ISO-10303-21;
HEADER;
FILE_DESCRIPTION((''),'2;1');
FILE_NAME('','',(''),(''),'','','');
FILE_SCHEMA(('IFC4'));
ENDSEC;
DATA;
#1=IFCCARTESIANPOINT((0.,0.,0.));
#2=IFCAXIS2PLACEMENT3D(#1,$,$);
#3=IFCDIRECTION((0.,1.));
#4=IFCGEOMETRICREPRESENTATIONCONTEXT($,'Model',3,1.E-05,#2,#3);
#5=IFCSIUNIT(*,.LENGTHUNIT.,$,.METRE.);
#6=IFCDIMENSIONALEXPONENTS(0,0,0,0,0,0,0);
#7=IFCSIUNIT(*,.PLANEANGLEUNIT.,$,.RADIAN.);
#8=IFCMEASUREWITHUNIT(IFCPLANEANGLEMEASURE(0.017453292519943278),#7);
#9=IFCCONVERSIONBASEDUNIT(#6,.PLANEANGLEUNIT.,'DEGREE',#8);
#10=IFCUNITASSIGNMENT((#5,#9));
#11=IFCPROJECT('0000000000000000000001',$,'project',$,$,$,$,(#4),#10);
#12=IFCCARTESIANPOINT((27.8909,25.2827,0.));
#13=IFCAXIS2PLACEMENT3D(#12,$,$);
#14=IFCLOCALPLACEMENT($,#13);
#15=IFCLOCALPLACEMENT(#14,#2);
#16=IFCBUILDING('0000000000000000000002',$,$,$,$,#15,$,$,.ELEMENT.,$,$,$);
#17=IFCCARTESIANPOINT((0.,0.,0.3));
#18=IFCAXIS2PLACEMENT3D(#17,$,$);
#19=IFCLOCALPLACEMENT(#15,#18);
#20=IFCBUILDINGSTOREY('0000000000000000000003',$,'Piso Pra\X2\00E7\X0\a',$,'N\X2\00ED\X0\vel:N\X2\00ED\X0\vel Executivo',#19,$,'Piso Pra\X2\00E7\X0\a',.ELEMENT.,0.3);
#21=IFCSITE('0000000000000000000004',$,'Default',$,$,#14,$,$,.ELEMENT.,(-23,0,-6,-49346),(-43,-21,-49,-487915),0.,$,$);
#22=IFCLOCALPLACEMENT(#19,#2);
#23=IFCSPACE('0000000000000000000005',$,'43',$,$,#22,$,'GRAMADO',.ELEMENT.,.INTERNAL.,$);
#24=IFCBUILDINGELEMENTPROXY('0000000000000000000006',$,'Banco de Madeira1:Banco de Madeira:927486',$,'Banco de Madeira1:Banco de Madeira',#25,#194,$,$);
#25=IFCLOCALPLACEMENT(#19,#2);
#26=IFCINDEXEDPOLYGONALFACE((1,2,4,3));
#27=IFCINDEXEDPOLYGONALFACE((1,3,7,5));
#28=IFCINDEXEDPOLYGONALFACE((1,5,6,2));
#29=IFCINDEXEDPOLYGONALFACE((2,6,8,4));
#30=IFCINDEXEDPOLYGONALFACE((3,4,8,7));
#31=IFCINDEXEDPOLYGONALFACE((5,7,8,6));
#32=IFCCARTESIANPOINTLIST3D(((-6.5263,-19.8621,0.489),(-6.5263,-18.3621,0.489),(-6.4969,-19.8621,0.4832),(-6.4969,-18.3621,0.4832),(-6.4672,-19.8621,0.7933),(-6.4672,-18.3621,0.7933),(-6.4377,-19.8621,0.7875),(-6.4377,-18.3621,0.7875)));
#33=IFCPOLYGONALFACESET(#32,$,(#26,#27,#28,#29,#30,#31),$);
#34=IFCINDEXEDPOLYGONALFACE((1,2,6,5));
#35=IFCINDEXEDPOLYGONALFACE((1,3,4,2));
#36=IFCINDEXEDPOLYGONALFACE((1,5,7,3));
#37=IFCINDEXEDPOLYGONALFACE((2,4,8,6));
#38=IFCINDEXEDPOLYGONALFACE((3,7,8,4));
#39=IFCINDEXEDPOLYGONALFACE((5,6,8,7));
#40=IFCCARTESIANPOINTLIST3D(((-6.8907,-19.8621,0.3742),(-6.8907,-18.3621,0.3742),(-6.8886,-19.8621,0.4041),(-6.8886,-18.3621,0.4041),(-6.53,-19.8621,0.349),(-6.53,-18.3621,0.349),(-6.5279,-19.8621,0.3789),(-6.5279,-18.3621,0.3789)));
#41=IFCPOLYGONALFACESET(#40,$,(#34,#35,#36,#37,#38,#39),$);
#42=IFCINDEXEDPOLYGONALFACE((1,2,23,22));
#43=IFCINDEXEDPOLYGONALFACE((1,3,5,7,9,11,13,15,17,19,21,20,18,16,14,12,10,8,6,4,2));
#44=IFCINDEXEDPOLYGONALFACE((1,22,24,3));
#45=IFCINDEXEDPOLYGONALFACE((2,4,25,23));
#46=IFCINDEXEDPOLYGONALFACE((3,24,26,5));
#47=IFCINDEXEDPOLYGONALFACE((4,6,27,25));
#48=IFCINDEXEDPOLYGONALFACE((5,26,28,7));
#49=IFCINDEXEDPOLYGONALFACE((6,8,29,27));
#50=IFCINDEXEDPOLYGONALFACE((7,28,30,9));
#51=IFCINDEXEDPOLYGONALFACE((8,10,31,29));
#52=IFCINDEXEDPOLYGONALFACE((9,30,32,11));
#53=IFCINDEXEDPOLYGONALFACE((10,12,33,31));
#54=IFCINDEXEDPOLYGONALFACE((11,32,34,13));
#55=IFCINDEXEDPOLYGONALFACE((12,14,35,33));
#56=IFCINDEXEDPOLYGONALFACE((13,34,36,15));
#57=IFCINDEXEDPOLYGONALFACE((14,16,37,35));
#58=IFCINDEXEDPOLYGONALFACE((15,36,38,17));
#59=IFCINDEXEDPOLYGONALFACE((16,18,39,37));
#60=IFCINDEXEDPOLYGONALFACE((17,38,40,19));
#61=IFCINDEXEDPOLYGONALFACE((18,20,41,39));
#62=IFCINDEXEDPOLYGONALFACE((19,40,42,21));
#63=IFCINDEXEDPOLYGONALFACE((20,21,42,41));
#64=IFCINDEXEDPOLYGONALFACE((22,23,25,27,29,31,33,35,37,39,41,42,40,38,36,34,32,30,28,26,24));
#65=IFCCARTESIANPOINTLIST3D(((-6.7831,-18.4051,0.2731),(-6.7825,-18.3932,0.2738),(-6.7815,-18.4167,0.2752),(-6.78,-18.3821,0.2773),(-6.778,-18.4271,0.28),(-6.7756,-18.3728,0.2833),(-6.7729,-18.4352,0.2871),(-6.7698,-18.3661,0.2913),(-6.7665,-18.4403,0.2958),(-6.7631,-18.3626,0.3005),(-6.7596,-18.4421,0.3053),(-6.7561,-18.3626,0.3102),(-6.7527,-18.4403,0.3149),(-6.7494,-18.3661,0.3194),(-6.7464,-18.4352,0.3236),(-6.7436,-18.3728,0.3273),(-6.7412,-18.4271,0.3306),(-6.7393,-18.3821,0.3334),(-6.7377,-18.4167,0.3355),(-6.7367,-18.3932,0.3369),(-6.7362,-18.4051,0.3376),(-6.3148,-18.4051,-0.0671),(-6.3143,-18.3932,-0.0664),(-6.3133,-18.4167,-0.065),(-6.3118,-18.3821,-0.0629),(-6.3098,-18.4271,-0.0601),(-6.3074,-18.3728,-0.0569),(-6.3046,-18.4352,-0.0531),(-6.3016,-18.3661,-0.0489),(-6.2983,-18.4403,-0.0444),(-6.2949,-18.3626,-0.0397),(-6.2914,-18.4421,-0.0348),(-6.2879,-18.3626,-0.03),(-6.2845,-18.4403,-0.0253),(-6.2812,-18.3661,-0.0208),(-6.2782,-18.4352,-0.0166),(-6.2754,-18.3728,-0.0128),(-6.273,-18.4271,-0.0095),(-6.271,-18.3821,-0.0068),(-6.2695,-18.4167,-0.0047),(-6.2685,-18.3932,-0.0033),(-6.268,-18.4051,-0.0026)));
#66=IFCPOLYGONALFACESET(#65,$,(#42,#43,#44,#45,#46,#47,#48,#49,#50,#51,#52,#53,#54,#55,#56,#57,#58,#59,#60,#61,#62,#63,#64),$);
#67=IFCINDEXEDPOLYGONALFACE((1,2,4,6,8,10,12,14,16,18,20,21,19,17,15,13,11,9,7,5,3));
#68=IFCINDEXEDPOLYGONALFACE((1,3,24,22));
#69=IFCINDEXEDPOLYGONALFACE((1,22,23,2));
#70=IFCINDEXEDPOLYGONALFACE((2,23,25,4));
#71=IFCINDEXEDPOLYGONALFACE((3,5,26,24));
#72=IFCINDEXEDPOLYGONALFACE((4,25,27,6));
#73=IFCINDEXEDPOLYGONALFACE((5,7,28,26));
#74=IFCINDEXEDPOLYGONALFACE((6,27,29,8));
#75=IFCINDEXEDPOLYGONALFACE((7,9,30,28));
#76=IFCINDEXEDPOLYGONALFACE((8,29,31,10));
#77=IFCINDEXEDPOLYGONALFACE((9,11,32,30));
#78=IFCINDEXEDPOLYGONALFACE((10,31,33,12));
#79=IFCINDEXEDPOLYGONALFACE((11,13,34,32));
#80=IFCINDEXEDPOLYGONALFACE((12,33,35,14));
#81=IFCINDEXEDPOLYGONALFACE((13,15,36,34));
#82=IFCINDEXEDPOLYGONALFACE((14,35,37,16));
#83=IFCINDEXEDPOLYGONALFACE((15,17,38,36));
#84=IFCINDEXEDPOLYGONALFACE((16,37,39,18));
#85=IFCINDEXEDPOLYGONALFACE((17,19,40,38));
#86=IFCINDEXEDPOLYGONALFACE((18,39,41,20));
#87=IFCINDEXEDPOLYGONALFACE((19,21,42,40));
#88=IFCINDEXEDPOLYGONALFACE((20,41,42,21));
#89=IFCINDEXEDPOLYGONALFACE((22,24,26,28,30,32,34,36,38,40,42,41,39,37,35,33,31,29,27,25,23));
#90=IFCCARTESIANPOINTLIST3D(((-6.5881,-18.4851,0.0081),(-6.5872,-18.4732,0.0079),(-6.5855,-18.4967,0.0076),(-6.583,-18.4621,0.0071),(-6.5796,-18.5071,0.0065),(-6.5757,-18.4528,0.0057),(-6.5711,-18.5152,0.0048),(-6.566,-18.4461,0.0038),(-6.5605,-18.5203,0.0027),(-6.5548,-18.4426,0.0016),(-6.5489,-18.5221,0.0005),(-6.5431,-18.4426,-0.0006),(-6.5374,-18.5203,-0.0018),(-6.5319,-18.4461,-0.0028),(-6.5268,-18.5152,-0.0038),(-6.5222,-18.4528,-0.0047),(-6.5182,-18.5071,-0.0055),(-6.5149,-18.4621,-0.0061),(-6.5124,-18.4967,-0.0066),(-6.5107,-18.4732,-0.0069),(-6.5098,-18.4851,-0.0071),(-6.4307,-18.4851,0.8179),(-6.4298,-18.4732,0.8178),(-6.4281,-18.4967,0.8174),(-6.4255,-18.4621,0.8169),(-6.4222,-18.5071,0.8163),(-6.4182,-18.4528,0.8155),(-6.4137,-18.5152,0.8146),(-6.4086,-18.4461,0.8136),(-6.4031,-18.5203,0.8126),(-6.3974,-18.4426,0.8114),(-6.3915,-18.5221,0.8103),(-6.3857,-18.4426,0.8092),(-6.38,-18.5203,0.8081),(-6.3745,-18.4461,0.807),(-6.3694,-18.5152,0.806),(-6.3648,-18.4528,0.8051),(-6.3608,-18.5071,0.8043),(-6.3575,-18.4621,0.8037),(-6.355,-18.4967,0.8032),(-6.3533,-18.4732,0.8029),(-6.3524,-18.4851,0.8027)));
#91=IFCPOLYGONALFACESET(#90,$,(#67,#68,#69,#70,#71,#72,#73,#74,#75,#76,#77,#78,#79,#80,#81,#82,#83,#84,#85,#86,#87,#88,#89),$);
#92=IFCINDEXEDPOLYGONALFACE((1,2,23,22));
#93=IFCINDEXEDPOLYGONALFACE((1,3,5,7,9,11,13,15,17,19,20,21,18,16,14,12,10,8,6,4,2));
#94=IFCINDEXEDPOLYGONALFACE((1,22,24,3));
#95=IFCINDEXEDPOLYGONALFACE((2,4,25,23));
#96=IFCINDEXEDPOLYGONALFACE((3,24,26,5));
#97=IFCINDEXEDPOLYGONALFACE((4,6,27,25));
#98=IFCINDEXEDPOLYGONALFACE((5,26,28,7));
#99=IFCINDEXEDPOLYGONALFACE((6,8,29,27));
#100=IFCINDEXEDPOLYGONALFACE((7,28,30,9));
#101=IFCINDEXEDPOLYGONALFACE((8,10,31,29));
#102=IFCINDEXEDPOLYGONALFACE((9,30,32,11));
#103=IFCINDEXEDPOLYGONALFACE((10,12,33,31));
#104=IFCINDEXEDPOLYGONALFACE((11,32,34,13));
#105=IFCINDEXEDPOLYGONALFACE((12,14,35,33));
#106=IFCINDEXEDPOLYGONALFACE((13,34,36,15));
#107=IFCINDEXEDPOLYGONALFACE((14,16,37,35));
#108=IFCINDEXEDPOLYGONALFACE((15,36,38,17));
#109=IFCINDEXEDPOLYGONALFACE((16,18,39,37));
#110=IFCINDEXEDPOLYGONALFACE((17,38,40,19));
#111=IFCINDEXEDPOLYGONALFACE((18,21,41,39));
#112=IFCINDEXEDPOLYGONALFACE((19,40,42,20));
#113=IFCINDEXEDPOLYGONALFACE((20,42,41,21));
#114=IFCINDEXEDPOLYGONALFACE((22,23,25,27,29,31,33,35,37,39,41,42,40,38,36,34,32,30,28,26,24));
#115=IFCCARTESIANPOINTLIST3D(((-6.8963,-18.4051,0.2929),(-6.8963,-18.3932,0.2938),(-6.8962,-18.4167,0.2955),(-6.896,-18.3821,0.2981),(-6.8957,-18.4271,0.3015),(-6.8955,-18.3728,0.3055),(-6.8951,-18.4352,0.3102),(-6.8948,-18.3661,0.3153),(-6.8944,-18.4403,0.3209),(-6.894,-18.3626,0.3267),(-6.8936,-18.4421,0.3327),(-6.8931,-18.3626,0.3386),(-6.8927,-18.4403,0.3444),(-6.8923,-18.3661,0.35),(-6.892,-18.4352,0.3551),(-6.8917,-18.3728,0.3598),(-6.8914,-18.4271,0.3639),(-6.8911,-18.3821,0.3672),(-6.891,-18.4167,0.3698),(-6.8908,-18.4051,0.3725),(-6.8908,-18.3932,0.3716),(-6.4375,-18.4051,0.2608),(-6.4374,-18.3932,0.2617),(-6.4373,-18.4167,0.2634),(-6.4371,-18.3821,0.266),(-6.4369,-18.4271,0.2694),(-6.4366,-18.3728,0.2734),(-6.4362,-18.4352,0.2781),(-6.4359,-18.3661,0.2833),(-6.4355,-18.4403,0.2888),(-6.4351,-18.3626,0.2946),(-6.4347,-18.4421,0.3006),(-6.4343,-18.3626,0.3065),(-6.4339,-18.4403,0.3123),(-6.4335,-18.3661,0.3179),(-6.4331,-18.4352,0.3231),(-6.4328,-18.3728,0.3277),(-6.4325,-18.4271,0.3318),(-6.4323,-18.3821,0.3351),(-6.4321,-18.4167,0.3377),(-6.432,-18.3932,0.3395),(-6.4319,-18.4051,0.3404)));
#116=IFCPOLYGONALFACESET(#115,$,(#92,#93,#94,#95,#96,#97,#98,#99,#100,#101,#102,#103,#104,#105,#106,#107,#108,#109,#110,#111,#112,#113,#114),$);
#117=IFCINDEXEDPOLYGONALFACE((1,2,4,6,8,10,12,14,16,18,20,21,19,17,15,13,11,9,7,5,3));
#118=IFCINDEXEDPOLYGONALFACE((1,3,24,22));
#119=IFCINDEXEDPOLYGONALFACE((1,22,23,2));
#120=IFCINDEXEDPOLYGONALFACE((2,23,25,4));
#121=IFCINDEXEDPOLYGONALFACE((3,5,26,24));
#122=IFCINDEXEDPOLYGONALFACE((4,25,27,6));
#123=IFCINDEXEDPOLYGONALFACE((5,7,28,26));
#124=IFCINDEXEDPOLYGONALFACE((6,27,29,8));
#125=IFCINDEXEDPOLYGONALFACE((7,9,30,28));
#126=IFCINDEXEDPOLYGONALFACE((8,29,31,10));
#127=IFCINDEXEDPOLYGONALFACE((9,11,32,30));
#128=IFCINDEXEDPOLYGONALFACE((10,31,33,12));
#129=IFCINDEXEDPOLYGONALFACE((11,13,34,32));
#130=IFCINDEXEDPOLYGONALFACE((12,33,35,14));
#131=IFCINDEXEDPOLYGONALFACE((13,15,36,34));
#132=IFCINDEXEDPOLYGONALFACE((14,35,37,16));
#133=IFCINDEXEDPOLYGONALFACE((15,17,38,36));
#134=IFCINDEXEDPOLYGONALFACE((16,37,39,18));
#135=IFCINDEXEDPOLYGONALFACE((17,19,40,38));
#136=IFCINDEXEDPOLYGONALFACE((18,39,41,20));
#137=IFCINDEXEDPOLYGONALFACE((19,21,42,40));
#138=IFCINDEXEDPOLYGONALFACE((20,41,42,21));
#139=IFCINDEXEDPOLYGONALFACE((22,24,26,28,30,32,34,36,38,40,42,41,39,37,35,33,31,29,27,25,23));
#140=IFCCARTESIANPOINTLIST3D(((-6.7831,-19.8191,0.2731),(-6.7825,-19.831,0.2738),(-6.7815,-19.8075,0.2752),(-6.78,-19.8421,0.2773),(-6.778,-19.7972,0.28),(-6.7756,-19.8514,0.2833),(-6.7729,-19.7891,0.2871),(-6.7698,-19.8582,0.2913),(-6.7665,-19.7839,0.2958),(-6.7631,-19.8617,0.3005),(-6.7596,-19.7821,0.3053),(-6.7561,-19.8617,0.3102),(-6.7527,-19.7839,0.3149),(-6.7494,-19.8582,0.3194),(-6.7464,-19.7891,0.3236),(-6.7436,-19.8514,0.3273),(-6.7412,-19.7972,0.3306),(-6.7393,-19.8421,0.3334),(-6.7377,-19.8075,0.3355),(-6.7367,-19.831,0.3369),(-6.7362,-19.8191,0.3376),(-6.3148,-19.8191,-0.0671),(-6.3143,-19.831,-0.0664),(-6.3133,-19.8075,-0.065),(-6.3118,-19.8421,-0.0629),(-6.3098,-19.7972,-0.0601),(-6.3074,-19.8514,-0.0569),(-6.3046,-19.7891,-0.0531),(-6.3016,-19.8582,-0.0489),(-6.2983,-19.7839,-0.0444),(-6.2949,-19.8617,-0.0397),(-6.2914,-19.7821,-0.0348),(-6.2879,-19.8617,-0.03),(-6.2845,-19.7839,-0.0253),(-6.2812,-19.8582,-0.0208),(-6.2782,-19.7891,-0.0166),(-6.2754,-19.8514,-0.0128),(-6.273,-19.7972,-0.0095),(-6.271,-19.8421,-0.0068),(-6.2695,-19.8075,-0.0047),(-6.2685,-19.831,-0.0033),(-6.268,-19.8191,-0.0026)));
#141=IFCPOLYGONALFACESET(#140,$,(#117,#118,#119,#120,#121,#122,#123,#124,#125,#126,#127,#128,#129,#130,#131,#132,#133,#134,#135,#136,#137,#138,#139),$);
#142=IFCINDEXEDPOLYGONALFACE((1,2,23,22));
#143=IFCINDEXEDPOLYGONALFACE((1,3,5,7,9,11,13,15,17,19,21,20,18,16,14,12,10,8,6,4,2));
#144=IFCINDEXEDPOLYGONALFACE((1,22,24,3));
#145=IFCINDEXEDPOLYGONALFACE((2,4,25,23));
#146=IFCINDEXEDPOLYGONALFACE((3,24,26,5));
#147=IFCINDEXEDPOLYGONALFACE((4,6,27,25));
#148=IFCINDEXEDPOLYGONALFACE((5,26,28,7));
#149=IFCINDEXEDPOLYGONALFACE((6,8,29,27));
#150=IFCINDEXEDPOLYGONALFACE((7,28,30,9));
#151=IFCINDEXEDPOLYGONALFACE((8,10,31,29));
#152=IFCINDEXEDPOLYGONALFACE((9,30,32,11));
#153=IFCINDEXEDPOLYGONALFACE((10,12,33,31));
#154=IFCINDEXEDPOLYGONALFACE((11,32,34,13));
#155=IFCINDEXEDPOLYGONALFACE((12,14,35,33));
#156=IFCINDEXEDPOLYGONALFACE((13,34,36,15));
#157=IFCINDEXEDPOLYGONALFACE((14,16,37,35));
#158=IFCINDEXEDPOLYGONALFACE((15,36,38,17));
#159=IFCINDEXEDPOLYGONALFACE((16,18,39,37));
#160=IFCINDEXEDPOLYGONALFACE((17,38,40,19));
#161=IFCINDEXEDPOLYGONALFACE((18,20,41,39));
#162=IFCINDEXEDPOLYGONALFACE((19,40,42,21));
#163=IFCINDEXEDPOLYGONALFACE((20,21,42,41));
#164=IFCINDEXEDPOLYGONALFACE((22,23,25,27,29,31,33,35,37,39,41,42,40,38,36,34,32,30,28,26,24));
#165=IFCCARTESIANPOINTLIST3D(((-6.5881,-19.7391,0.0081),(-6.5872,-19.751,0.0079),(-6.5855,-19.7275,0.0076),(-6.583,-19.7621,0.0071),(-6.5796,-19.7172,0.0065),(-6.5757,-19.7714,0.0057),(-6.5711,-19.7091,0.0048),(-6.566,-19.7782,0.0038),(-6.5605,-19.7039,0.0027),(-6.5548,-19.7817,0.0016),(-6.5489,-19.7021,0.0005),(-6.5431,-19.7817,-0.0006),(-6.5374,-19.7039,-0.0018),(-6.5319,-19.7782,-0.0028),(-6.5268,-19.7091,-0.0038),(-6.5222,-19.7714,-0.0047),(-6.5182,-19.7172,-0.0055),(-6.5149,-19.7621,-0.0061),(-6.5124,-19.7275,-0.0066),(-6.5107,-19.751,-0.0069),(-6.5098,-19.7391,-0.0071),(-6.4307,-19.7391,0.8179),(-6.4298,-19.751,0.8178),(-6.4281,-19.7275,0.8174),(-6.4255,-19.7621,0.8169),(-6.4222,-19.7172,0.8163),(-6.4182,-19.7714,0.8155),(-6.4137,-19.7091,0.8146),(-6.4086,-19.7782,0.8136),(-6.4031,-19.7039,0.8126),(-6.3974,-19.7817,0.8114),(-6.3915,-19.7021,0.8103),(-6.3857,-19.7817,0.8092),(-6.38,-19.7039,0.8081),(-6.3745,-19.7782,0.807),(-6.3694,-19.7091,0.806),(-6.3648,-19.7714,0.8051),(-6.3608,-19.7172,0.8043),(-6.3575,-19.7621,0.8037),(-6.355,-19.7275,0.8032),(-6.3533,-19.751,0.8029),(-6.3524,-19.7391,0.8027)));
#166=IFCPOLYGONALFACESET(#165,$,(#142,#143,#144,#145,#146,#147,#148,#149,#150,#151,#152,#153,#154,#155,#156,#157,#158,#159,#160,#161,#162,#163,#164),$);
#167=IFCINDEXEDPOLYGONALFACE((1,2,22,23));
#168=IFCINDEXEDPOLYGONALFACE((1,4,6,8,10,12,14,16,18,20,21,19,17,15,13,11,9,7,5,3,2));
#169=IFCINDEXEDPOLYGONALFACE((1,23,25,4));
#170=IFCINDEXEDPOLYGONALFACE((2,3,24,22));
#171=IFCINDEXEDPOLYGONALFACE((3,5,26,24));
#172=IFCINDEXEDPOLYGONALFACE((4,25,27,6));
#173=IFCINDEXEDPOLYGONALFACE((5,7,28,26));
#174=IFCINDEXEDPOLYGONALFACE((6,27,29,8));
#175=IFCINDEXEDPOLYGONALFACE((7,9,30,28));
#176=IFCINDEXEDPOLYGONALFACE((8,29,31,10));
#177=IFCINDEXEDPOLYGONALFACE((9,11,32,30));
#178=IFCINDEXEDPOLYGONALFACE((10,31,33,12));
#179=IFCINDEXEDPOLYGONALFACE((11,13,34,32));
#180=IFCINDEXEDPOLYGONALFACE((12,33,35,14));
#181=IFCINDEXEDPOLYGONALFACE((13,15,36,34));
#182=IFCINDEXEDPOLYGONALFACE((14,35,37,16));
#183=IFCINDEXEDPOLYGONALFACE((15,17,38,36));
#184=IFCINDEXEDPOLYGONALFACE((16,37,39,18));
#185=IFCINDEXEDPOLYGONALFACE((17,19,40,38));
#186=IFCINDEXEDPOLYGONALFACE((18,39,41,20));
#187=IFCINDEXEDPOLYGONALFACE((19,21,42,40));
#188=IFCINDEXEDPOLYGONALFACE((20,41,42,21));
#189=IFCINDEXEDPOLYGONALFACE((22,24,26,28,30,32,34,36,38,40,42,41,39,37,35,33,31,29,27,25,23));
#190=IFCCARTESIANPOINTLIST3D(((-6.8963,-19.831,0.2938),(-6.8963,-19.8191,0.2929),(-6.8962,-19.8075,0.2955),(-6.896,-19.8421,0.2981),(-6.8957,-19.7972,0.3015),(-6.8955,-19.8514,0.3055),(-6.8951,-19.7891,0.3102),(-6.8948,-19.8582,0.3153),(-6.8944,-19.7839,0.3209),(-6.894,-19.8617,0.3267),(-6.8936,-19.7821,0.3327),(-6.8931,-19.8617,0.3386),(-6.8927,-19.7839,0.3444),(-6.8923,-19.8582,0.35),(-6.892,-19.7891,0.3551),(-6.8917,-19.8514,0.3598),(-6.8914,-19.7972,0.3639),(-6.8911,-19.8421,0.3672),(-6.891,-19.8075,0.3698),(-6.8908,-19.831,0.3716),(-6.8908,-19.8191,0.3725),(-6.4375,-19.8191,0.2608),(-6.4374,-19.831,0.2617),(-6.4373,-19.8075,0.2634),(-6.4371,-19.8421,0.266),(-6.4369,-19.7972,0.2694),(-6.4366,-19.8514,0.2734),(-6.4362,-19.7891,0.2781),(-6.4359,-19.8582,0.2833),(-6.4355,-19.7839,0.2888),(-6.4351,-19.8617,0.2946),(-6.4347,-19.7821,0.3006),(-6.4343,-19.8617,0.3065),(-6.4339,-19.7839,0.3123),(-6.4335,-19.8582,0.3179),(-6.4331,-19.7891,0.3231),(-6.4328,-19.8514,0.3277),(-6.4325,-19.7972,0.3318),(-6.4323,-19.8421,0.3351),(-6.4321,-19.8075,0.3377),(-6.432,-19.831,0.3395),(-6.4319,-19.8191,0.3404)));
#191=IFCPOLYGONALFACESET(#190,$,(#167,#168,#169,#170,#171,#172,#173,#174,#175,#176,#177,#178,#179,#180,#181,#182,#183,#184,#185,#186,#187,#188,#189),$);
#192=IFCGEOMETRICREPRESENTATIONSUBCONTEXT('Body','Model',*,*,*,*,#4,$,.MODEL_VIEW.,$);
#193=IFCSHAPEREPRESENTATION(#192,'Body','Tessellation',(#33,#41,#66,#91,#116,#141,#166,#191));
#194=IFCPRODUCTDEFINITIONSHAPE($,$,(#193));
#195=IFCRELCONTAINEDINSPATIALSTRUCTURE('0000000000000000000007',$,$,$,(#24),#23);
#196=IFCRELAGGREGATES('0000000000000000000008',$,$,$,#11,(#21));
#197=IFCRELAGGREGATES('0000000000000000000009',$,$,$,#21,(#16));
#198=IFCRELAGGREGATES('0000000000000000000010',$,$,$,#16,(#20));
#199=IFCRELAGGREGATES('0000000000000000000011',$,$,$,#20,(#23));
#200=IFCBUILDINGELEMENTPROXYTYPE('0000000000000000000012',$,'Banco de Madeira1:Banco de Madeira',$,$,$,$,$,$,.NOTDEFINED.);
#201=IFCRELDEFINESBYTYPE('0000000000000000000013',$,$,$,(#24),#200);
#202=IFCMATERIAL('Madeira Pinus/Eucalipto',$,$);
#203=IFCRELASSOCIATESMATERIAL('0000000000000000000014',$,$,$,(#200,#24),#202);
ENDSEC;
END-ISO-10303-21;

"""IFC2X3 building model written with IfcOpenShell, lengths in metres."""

from ifc_helpers import new_model, entity, si_unit, converted_unit, direction, frame, frame_2d, origin, place, context, subcontext, project, spatial, rectangle, circle, extrude, source, transform, mapped, material, type_object, type_shapes, element, save


model = new_model("IFC2X3")

# Units and contexts
model_context = context("Model", 3, precision=1e-05, world=origin(), true_north=direction((0.0, 1.0)))
body_context = subcontext(model_context, "Body", "Model", "MODEL_VIEW")
ifc_project = project(units=[si_unit("LENGTHUNIT", "METRE"), converted_unit("PLANEANGLEUNIT", "DEGREE", entity("IfcPlaneAngleMeasure", 0.017453292519943278), si_unit("PLANEANGLEUNIT", "RADIAN"), dimensions=[0, 0, 0, 0, 0, 0, 0])], contexts=[model_context])

# Site, building, storey
site_placement = place(None, frame((27.8909, 25.2827, 0.0)))
site = spatial("IfcSite", under=ifc_project, at=site_placement, Name="Default", CompositionType="ELEMENT", RefLatitude=(-23, 0, -6, -49346), RefLongitude=(-43, -21, -49, -487915), RefElevation=0.0)
building_placement = place(site_placement, origin())
building = spatial("IfcBuilding", under=site, at=building_placement, CompositionType="ELEMENT")
storey_placement = place(building_placement, frame((0.0, 0.0, 0.3)))
storey = spatial("IfcBuildingStorey", under=building, at=storey_placement, Name="Piso Praça", ObjectType="Nível:Nível Executivo", LongName="Piso Praça", CompositionType="ELEMENT", Elevation=0.3)

# Shared definitions
space_1_placement = place(storey_placement, origin())
space_1 = spatial("IfcSpace", under=storey, at=space_1_placement, Name="43", LongName="GRAMADO", CompositionType="ELEMENT", InteriorOrExteriorSpace="INTERNAL")

# Building element proxy
ifc_material_1 = material(Name="Madeira Pinus/Eucalipto")
building_element_proxy_type_1 = type_object("IfcBuildingElementProxyType", Name="Banco de Madeira1:Banco de Madeira", PredefinedType="NOTDEFINED", material=ifc_material_1)
shared_shape_1 = source(origin(), body_context, "Body", "SweptSolid", [
    extrude(rectangle(XDim=0.31, YDim=0.03, at=frame_2d((0.0, 0.0), x_axis=(0.0, 1.0))), frame((-0.75, -0.1439, 0.6383), z_axis=(1.0, 0.0, 0.0), x_axis=(0.0, 0.981627, 0.190809)), (0.0, 0.0, 1.0), 1.5),
    extrude(rectangle(XDim=0.03, YDim=0.3616, at=frame_2d((0.0, 0.0), x_axis=(1.0, 0.0))), frame((-0.75, 0.0833, 0.3765), z_axis=(1.0, 0.0, 0.0), x_axis=(0.0, -0.069756, 0.997564)), (0.0, 0.0, 1.0), 1.5),
    extrude(circle(Radius=0.04, at=frame_2d((0.0, 0.0), x_axis=(1.0, 0.0))), frame((0.71, -0.3345, -0.0348), z_axis=(0.0, 0.809017, 0.587785), x_axis=(-1.0, 0.0, 0.0)), (0.0, 0.0, 1.0), 0.5788),
    extrude(circle(Radius=0.04, at=frame_2d((0.0, 0.0), x_axis=(1.0, 0.0))), frame((0.63, -0.2344, 0.8103), z_axis=(0.0, 0.190809, -0.981627), x_axis=(-1.0, 0.0, 0.0)), (0.0, 0.0, 1.0), 0.825),
    extrude(circle(Radius=0.04, at=frame_2d((0.0, 0.0), x_axis=(1.0, 0.0))), frame((0.71, -0.1913, 0.3006), z_axis=(0.0, 0.997564, 0.069756), x_axis=(-1.0, 0.0, 0.0)), (0.0, 0.0, 1.0), 0.46),
    extrude(circle(Radius=0.04, at=frame_2d((0.0, 0.0), x_axis=(1.0, 0.0))), frame((-0.71, -0.3345, -0.0348), z_axis=(0.0, 0.809017, 0.587785), x_axis=(1.0, 0.0, 0.0)), (0.0, 0.0, 1.0), 0.5788),
    extrude(circle(Radius=0.04, at=frame_2d((0.0, 0.0), x_axis=(1.0, 0.0))), frame((-0.63, -0.2344, 0.8103), z_axis=(0.0, 0.190809, -0.981627), x_axis=(1.0, 0.0, 0.0)), (0.0, 0.0, 1.0), 0.825),
    extrude(circle(Radius=0.04, at=frame_2d((0.0, 0.0), x_axis=(1.0, 0.0))), frame((-0.71, -0.1913, 0.3006), z_axis=(0.0, 0.997564, 0.069756), x_axis=(1.0, 0.0, 0.0)), (0.0, 0.0, 1.0), 0.46),
])
type_shapes(building_element_proxy_type_1, [shared_shape_1])
proxy_1_placement = place(space_1_placement, frame((-6.6259, -19.1121, 0.0), z_axis=(0.0, 0.0, 1.0), x_axis=(0.0, 1.0, 0.0)))
element("IfcBuildingElementProxy", 1, at=proxy_1_placement, inside=space_1, type_object=building_element_proxy_type_1, material=ifc_material_1, Name="Banco de Madeira1:Banco de Madeira:927486", ObjectType="Banco de Madeira1:Banco de Madeira", context=body_context, shape_type="MappedRepresentation", body=[
    mapped(shared_shape_1, transform((0.0, 0.0, 0.0), scale=1.0)),
])

save(model, "model.ifc")
